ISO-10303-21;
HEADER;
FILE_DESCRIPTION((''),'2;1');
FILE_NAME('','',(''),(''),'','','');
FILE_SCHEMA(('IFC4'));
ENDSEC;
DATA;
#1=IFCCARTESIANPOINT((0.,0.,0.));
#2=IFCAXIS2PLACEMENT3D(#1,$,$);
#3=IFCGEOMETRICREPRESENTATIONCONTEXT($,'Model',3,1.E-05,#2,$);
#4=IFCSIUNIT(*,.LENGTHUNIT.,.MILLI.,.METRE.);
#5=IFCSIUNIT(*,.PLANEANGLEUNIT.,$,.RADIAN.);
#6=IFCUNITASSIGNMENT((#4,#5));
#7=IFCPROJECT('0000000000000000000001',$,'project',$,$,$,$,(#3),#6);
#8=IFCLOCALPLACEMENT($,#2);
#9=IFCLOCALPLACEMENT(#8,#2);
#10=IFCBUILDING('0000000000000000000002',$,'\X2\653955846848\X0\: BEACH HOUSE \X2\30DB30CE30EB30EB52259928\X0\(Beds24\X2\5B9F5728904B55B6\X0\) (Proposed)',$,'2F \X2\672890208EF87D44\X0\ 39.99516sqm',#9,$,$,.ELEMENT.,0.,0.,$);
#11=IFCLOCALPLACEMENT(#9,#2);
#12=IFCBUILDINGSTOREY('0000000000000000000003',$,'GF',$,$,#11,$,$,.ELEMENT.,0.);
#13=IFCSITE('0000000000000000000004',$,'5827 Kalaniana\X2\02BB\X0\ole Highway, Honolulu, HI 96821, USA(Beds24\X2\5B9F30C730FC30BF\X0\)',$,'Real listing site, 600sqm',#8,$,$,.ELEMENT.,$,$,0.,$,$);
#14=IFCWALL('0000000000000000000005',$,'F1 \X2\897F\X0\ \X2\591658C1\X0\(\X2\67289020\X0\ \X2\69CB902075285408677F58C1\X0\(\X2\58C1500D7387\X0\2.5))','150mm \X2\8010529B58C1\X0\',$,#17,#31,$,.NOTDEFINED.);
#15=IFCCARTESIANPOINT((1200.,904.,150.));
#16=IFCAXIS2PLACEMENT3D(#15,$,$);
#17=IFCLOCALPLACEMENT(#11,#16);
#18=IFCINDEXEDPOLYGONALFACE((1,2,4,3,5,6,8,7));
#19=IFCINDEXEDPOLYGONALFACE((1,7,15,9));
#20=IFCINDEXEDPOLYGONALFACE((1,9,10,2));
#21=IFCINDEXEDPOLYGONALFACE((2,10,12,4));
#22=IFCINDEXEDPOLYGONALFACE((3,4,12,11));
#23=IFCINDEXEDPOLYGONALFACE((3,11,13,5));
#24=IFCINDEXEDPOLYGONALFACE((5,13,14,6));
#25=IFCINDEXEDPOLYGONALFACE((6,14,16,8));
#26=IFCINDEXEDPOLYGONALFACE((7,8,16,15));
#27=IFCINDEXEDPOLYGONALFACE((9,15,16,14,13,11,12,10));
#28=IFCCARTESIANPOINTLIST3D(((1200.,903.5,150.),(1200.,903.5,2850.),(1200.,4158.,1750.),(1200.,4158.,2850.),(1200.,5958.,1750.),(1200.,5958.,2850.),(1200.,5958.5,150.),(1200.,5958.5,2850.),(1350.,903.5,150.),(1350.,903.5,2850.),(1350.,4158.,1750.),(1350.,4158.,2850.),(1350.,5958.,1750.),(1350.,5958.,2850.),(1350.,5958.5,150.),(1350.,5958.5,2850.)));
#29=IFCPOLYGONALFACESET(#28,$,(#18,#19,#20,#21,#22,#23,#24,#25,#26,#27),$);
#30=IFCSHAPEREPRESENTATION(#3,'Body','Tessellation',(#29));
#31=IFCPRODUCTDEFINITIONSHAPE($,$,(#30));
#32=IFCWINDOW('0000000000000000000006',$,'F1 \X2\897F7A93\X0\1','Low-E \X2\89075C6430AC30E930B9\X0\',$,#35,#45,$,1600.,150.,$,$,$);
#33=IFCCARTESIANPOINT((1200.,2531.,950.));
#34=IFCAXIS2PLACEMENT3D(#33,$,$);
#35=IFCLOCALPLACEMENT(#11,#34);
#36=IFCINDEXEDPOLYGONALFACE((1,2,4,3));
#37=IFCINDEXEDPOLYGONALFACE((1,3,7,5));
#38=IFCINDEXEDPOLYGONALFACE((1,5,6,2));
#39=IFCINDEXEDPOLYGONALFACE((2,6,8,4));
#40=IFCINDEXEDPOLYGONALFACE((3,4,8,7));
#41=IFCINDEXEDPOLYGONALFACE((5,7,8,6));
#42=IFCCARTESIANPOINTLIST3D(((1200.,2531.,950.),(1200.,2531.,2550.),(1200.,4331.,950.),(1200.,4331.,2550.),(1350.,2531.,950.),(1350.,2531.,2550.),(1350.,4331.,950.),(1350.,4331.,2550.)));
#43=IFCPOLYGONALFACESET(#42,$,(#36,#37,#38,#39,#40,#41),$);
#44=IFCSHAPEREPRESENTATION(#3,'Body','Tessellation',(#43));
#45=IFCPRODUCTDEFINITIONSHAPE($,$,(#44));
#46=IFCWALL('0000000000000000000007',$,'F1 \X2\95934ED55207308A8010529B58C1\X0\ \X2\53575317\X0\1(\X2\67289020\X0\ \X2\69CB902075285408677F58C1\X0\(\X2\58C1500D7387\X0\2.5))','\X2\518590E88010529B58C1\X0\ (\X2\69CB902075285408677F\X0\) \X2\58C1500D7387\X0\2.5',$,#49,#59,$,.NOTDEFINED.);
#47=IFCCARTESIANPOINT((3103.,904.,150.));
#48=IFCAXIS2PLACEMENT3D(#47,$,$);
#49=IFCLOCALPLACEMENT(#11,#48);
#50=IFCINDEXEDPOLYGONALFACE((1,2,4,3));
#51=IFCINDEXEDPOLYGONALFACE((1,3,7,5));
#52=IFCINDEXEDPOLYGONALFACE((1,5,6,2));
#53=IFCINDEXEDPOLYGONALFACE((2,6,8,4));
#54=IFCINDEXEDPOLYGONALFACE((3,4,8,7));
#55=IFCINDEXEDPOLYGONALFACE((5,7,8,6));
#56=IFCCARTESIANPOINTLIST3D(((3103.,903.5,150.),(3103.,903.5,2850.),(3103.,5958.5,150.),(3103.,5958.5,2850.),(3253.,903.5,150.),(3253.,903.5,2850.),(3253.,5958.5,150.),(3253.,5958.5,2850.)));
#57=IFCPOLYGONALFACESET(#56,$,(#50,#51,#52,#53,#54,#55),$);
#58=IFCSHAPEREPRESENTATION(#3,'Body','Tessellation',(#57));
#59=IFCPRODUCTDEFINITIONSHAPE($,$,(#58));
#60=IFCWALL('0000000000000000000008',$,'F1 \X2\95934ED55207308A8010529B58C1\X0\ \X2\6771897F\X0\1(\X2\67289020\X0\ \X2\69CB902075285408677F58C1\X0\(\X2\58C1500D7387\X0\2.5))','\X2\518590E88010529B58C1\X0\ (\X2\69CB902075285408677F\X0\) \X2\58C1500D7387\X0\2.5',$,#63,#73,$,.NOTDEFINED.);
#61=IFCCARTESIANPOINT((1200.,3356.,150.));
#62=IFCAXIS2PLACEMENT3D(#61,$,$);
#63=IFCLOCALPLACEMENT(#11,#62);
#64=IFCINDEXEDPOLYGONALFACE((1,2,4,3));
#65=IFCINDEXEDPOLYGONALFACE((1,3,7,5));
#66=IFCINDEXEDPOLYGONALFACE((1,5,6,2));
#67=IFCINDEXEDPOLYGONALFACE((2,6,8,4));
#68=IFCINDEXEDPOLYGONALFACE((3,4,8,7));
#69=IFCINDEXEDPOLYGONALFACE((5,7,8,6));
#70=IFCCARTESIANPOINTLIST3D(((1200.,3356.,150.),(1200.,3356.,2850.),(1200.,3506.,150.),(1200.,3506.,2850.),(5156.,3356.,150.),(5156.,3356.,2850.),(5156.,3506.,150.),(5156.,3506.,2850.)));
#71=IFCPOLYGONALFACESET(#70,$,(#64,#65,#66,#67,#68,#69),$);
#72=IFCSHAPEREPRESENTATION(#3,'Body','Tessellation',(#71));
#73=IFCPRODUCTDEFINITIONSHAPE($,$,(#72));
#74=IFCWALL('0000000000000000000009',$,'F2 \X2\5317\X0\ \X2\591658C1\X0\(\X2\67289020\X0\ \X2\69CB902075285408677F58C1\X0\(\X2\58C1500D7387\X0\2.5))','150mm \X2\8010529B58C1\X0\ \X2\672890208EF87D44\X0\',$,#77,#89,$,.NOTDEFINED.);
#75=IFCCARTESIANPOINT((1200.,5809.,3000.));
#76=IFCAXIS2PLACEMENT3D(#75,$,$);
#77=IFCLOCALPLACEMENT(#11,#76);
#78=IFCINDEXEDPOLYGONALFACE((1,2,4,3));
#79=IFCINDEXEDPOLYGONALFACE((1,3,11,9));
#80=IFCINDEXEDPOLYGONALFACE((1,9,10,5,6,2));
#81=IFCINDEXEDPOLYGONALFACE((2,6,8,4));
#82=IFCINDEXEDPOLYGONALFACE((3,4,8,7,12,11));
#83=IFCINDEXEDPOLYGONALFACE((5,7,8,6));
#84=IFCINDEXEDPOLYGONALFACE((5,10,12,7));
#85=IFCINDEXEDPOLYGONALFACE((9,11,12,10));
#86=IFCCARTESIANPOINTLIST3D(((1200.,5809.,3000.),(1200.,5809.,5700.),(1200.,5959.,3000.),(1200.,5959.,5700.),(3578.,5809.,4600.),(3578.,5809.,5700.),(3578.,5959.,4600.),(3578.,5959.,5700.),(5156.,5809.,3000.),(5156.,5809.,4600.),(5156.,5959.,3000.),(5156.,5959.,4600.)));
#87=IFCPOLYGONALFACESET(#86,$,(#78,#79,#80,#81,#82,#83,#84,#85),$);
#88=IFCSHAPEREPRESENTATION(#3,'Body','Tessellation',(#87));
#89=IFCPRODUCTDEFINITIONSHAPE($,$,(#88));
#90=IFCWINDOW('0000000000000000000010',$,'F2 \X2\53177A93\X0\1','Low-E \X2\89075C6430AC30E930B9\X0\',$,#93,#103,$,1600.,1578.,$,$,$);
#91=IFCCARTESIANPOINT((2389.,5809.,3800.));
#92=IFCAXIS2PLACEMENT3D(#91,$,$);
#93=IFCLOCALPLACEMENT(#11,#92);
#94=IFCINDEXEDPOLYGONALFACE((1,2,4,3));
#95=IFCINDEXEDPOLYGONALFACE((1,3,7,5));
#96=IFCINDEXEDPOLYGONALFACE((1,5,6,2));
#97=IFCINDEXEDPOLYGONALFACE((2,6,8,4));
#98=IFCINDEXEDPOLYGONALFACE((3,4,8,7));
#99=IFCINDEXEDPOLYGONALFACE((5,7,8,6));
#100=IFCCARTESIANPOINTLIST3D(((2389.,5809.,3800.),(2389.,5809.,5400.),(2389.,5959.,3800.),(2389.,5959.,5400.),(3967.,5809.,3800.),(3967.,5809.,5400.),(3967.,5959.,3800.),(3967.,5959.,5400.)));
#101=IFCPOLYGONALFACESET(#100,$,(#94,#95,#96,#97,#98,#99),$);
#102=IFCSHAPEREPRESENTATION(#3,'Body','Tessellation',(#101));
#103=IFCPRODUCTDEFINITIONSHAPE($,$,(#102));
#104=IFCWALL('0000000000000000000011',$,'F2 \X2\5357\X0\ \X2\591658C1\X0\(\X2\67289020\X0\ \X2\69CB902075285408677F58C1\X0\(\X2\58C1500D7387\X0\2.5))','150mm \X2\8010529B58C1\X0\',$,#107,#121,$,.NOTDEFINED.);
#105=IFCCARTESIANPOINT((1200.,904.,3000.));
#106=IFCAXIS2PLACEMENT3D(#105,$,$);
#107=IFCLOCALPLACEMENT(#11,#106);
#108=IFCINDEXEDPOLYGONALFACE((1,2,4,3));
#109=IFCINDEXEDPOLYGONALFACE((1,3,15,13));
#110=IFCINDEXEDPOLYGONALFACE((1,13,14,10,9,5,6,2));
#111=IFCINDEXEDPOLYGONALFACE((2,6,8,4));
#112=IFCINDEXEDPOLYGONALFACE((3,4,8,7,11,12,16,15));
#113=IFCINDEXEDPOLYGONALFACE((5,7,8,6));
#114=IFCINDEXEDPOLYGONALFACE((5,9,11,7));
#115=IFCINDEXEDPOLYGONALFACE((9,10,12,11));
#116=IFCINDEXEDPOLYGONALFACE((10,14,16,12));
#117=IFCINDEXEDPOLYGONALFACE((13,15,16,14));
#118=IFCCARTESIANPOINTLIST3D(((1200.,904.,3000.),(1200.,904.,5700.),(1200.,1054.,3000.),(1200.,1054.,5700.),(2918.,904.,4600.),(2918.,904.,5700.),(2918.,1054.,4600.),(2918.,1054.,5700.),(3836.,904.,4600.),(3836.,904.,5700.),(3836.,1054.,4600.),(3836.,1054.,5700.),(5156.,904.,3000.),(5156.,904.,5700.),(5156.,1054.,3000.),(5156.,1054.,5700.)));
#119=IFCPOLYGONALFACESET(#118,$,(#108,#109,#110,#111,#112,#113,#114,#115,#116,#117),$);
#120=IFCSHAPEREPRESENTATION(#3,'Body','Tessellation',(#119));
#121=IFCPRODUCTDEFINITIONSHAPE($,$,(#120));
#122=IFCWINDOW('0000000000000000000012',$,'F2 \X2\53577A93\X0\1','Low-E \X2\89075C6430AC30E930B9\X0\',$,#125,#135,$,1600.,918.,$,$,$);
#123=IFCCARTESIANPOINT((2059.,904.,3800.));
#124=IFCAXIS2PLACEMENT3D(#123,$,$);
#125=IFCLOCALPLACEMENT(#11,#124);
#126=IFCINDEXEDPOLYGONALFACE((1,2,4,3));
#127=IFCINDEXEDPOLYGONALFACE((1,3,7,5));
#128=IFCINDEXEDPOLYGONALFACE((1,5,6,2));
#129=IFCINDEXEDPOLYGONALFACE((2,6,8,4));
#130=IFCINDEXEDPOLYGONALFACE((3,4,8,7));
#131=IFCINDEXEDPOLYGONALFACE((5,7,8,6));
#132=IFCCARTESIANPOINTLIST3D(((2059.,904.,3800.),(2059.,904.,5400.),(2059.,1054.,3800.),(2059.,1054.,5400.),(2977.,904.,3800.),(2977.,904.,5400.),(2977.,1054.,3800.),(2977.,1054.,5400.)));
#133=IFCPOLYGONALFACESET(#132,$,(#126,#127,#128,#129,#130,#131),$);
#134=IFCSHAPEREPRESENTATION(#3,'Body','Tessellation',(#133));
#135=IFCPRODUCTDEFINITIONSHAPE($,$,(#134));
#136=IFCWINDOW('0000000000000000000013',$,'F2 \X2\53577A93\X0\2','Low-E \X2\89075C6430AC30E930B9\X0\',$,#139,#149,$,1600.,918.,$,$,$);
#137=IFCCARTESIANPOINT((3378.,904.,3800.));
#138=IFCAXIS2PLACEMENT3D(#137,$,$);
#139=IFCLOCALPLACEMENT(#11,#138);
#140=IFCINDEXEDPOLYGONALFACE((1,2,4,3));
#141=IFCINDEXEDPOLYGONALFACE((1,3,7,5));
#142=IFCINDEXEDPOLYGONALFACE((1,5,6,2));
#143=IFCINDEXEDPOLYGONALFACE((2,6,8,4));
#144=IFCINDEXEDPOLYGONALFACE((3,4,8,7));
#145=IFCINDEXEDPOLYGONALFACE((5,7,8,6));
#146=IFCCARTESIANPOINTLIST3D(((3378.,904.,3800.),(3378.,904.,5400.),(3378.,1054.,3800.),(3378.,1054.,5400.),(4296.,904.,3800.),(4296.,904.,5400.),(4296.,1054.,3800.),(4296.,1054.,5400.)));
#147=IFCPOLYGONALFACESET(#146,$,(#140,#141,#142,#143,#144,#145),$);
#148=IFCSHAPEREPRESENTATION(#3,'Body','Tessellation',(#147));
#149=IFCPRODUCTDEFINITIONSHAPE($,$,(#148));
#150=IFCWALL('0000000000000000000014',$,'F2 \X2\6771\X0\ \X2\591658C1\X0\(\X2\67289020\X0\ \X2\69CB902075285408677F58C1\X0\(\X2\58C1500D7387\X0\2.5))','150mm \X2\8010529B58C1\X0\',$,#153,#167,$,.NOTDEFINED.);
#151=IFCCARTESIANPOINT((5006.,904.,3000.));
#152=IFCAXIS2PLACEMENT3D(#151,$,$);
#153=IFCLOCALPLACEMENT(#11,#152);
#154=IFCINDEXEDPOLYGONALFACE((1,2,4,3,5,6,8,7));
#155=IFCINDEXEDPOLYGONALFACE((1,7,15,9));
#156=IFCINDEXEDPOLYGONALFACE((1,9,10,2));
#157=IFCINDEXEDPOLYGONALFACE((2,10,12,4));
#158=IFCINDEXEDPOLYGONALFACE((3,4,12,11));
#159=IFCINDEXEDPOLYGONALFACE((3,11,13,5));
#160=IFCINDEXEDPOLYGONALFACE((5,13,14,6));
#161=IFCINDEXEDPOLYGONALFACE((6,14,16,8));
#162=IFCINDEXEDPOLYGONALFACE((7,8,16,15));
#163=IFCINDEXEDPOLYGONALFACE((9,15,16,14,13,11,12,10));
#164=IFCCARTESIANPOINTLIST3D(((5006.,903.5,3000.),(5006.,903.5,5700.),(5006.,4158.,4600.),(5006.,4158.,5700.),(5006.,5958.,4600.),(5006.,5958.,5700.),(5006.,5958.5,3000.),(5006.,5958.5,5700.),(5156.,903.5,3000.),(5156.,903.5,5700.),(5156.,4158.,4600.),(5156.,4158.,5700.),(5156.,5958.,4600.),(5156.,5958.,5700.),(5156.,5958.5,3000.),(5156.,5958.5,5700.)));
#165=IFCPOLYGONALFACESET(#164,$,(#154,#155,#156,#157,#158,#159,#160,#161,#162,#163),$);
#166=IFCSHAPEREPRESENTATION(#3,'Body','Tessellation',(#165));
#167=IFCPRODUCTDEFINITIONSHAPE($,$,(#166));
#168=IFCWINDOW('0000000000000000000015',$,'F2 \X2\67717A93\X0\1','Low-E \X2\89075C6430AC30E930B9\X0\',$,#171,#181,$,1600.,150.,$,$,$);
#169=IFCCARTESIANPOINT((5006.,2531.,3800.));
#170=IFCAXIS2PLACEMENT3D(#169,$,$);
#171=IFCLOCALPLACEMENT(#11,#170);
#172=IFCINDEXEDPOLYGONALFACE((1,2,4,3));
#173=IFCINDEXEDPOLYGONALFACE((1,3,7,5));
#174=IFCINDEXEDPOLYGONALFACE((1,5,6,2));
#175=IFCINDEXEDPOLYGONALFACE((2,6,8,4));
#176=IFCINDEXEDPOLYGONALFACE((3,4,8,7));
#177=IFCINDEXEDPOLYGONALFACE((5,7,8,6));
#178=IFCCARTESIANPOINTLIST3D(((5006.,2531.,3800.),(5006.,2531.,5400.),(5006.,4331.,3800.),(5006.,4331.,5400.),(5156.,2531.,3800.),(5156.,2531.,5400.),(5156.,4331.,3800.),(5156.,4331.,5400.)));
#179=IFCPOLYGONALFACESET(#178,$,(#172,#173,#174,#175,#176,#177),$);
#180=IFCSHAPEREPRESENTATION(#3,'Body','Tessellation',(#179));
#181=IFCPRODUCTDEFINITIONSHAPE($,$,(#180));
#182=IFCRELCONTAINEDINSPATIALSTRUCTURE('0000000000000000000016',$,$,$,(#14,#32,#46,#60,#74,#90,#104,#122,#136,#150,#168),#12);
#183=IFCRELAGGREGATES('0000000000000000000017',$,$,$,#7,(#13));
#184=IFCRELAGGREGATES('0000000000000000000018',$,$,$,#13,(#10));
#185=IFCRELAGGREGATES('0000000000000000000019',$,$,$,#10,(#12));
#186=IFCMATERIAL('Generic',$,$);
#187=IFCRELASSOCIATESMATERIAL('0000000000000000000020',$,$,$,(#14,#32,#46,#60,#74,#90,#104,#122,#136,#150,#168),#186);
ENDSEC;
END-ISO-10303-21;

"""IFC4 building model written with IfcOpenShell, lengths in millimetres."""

from ifc_helpers import new_model, si_unit, frame, frame_2d, origin, place, context, project, spatial, rectangle, extrude, material, element, fill, save


model = new_model("IFC4")

# Units and contexts
model_context = context("Model", 3, precision=1e-05, world=origin())
ifc_project = project(units=[si_unit("LENGTHUNIT", "METRE", prefix="MILLI"), si_unit("PLANEANGLEUNIT", "RADIAN")], contexts=[model_context])

# Site, building, storey
site_placement = place(None, origin())
site = spatial("IfcSite", under=ifc_project, at=site_placement, Name="5827 Kalanianaʻole Highway, Honolulu, HI 96821, USA(Beds24実データ)", ObjectType="Real listing site, 600sqm", CompositionType="ELEMENT", RefElevation=0.0)
building_placement = place(site_placement, origin())
building = spatial("IfcBuilding", under=site, at=building_placement, Name="改善案: BEACH HOUSE ホノルル別館(Beds24実在運営) (Proposed)", ObjectType="2F 木造軸組 39.99516sqm", CompositionType="ELEMENT", ElevationOfRefHeight=0.0, ElevationOfTerrain=0.0)
storey_placement = place(building_placement, origin())
storey = spatial("IfcBuildingStorey", under=building, at=storey_placement, Name="GF", CompositionType="ELEMENT", Elevation=0.0)

# Shared definitions
ifc_material_1 = material(Name="Generic")

# Wall, opening, window
wall_1_placement = place(storey_placement, frame((1200.0, 904.0, 150.0)))
wall_1 = element("IfcWall", 1, at=wall_1_placement, inside=storey, material=ifc_material_1, Name="F1 西 外壁(木造 構造用合板壁(壁倍率2.5))", Description="150mm 耐力壁", PredefinedType="NOTDEFINED", context=model_context, shape_type="SweptSolid", body=[
    extrude(rectangle(XDim=150.0, YDim=5055.0, at=frame_2d((75.0, 2527.0))), frame((1200.0, 904.0, 150.0)), (0.0, 0.0, 1.0), 2700.0),
])
opening_1_placement = place(storey_placement, frame((1200.0, 2531.0, 950.0)))
opening_1 = element("IfcOpeningElement", 2, at=opening_1_placement, cuts=wall_1, PredefinedType="NOTDEFINED", context=model_context, shape_type="SweptSolid", body=[
    extrude(rectangle(XDim=150.0, YDim=1800.0, at=frame_2d((75.0, 900.0))), frame((1200.0, 2531.0, 950.0)), (0.0, 0.0, 1.0), 1600.0),
])
window_1_placement = place(storey_placement, frame((1200.0, 2531.0, 950.0)))
window_1 = element("IfcWindow", 3, at=window_1_placement, inside=storey, material=ifc_material_1, Name="F1 西窓1", Description="Low-E 複層ガラス", OverallHeight=1600.0, OverallWidth=150.0, context=model_context, shape_type="SweptSolid", body=[
    extrude(rectangle(XDim=150.0, YDim=1800.0, at=frame_2d((75.0, 900.0))), frame((1200.0, 2531.0, 950.0)), (0.0, 0.0, 1.0), 1600.0),
])
fill(opening_1, window_1)

# Walls
wall_2_placement = place(storey_placement, frame((3103.0, 904.0, 150.0)))
element("IfcWall", 4, at=wall_2_placement, inside=storey, material=ifc_material_1, Name="F1 間仕切り耐力壁 南北1(木造 構造用合板壁(壁倍率2.5))", Description="内部耐力壁 (構造用合板) 壁倍率2.5", PredefinedType="NOTDEFINED", context=model_context, shape_type="SweptSolid", body=[
    extrude(rectangle(XDim=150.0, YDim=5055.0, at=frame_2d((75.0, 2527.0))), frame((3103.0, 904.0, 150.0)), (0.0, 0.0, 1.0), 2700.0),
])
wall_3_placement = place(storey_placement, frame((1200.0, 3356.0, 150.0)))
element("IfcWall", 5, at=wall_3_placement, inside=storey, material=ifc_material_1, Name="F1 間仕切り耐力壁 東西1(木造 構造用合板壁(壁倍率2.5))", Description="内部耐力壁 (構造用合板) 壁倍率2.5", PredefinedType="NOTDEFINED", context=model_context, shape_type="SweptSolid", body=[
    extrude(rectangle(XDim=3956.0, YDim=150.0, at=frame_2d((1978.0, 75.0))), frame((1200.0, 3356.0, 150.0)), (0.0, 0.0, 1.0), 2700.0),
])

# Wall, opening, window
wall_4_placement = place(storey_placement, frame((1200.0, 5809.0, 3000.0)))
wall_4 = element("IfcWall", 6, at=wall_4_placement, inside=storey, material=ifc_material_1, Name="F2 北 外壁(木造 構造用合板壁(壁倍率2.5))", Description="150mm 耐力壁 木造軸組", PredefinedType="NOTDEFINED", context=model_context, shape_type="SweptSolid", body=[
    extrude(rectangle(XDim=3956.0, YDim=150.0, at=frame_2d((1978.0, 75.0))), frame((1200.0, 5809.0, 3000.0)), (0.0, 0.0, 1.0), 2700.0),
])
opening_2_placement = place(storey_placement, frame((2389.0, 5809.0, 3800.0)))
opening_2 = element("IfcOpeningElement", 7, at=opening_2_placement, cuts=wall_4, PredefinedType="NOTDEFINED", context=model_context, shape_type="SweptSolid", body=[
    extrude(rectangle(XDim=1578.0, YDim=150.0, at=frame_2d((789.0, 75.0))), frame((2389.0, 5809.0, 3800.0)), (0.0, 0.0, 1.0), 1600.0),
])
window_2_placement = place(storey_placement, frame((2389.0, 5809.0, 3800.0)))
window_2 = element("IfcWindow", 8, at=window_2_placement, inside=storey, material=ifc_material_1, Name="F2 北窓1", Description="Low-E 複層ガラス", OverallHeight=1600.0, OverallWidth=1578.0, context=model_context, shape_type="SweptSolid", body=[
    extrude(rectangle(XDim=1578.0, YDim=150.0, at=frame_2d((789.0, 75.0))), frame((2389.0, 5809.0, 3800.0)), (0.0, 0.0, 1.0), 1600.0),
])
fill(opening_2, window_2)

# Wall, openings, windows
wall_5_placement = place(storey_placement, frame((1200.0, 904.0, 3000.0)))
wall_5 = element("IfcWall", 9, at=wall_5_placement, inside=storey, material=ifc_material_1, Name="F2 南 外壁(木造 構造用合板壁(壁倍率2.5))", Description="150mm 耐力壁", PredefinedType="NOTDEFINED", context=model_context, shape_type="SweptSolid", body=[
    extrude(rectangle(XDim=3956.0, YDim=150.0, at=frame_2d((1978.0, 75.0))), frame((1200.0, 904.0, 3000.0)), (0.0, 0.0, 1.0), 2700.0),
])
opening_3_placement = place(storey_placement, frame((2059.0, 904.0, 3800.0)))
opening_3 = element("IfcOpeningElement", 10, at=opening_3_placement, cuts=wall_5, PredefinedType="NOTDEFINED", context=model_context, shape_type="SweptSolid", body=[
    extrude(rectangle(XDim=918.0, YDim=150.0, at=frame_2d((459.0, 75.0))), frame((2059.0, 904.0, 3800.0)), (0.0, 0.0, 1.0), 1600.0),
])
opening_4_placement = place(storey_placement, frame((3378.0, 904.0, 3800.0)))
opening_4 = element("IfcOpeningElement", 11, at=opening_4_placement, cuts=wall_5, PredefinedType="NOTDEFINED", context=model_context, shape_type="SweptSolid", body=[
    extrude(rectangle(XDim=918.0, YDim=150.0, at=frame_2d((459.0, 75.0))), frame((3378.0, 904.0, 3800.0)), (0.0, 0.0, 1.0), 1600.0),
])
window_3_placement = place(storey_placement, frame((2059.0, 904.0, 3800.0)))
window_3 = element("IfcWindow", 12, at=window_3_placement, inside=storey, material=ifc_material_1, Name="F2 南窓1", Description="Low-E 複層ガラス", OverallHeight=1600.0, OverallWidth=918.0, context=model_context, shape_type="SweptSolid", body=[
    extrude(rectangle(XDim=918.0, YDim=150.0, at=frame_2d((459.0, 75.0))), frame((2059.0, 904.0, 3800.0)), (0.0, 0.0, 1.0), 1600.0),
])
fill(opening_3, window_3)
window_4_placement = place(storey_placement, frame((3378.0, 904.0, 3800.0)))
window_4 = element("IfcWindow", 13, at=window_4_placement, inside=storey, material=ifc_material_1, Name="F2 南窓2", Description="Low-E 複層ガラス", OverallHeight=1600.0, OverallWidth=918.0, context=model_context, shape_type="SweptSolid", body=[
    extrude(rectangle(XDim=918.0, YDim=150.0, at=frame_2d((459.0, 75.0))), frame((3378.0, 904.0, 3800.0)), (0.0, 0.0, 1.0), 1600.0),
])
fill(opening_4, window_4)

# Wall, opening, window
wall_6_placement = place(storey_placement, frame((5006.0, 904.0, 3000.0)))
wall_6 = element("IfcWall", 14, at=wall_6_placement, inside=storey, material=ifc_material_1, Name="F2 東 外壁(木造 構造用合板壁(壁倍率2.5))", Description="150mm 耐力壁", PredefinedType="NOTDEFINED", context=model_context, shape_type="SweptSolid", body=[
    extrude(rectangle(XDim=150.0, YDim=5055.0, at=frame_2d((75.0, 2527.0))), frame((5006.0, 904.0, 3000.0)), (0.0, 0.0, 1.0), 2700.0),
])
opening_5_placement = place(storey_placement, frame((5006.0, 2531.0, 3800.0)))
opening_5 = element("IfcOpeningElement", 15, at=opening_5_placement, cuts=wall_6, PredefinedType="NOTDEFINED", context=model_context, shape_type="SweptSolid", body=[
    extrude(rectangle(XDim=150.0, YDim=1800.0, at=frame_2d((75.0, 900.0))), frame((5006.0, 2531.0, 3800.0)), (0.0, 0.0, 1.0), 1600.0),
])
window_5_placement = place(storey_placement, frame((5006.0, 2531.0, 3800.0)))
window_5 = element("IfcWindow", 16, at=window_5_placement, inside=storey, material=ifc_material_1, Name="F2 東窓1", Description="Low-E 複層ガラス", OverallHeight=1600.0, OverallWidth=150.0, context=model_context, shape_type="SweptSolid", body=[
    extrude(rectangle(XDim=150.0, YDim=1800.0, at=frame_2d((75.0, 900.0))), frame((5006.0, 2531.0, 3800.0)), (0.0, 0.0, 1.0), 1600.0),
])
fill(opening_5, window_5)

save(model, "model.ifc")
